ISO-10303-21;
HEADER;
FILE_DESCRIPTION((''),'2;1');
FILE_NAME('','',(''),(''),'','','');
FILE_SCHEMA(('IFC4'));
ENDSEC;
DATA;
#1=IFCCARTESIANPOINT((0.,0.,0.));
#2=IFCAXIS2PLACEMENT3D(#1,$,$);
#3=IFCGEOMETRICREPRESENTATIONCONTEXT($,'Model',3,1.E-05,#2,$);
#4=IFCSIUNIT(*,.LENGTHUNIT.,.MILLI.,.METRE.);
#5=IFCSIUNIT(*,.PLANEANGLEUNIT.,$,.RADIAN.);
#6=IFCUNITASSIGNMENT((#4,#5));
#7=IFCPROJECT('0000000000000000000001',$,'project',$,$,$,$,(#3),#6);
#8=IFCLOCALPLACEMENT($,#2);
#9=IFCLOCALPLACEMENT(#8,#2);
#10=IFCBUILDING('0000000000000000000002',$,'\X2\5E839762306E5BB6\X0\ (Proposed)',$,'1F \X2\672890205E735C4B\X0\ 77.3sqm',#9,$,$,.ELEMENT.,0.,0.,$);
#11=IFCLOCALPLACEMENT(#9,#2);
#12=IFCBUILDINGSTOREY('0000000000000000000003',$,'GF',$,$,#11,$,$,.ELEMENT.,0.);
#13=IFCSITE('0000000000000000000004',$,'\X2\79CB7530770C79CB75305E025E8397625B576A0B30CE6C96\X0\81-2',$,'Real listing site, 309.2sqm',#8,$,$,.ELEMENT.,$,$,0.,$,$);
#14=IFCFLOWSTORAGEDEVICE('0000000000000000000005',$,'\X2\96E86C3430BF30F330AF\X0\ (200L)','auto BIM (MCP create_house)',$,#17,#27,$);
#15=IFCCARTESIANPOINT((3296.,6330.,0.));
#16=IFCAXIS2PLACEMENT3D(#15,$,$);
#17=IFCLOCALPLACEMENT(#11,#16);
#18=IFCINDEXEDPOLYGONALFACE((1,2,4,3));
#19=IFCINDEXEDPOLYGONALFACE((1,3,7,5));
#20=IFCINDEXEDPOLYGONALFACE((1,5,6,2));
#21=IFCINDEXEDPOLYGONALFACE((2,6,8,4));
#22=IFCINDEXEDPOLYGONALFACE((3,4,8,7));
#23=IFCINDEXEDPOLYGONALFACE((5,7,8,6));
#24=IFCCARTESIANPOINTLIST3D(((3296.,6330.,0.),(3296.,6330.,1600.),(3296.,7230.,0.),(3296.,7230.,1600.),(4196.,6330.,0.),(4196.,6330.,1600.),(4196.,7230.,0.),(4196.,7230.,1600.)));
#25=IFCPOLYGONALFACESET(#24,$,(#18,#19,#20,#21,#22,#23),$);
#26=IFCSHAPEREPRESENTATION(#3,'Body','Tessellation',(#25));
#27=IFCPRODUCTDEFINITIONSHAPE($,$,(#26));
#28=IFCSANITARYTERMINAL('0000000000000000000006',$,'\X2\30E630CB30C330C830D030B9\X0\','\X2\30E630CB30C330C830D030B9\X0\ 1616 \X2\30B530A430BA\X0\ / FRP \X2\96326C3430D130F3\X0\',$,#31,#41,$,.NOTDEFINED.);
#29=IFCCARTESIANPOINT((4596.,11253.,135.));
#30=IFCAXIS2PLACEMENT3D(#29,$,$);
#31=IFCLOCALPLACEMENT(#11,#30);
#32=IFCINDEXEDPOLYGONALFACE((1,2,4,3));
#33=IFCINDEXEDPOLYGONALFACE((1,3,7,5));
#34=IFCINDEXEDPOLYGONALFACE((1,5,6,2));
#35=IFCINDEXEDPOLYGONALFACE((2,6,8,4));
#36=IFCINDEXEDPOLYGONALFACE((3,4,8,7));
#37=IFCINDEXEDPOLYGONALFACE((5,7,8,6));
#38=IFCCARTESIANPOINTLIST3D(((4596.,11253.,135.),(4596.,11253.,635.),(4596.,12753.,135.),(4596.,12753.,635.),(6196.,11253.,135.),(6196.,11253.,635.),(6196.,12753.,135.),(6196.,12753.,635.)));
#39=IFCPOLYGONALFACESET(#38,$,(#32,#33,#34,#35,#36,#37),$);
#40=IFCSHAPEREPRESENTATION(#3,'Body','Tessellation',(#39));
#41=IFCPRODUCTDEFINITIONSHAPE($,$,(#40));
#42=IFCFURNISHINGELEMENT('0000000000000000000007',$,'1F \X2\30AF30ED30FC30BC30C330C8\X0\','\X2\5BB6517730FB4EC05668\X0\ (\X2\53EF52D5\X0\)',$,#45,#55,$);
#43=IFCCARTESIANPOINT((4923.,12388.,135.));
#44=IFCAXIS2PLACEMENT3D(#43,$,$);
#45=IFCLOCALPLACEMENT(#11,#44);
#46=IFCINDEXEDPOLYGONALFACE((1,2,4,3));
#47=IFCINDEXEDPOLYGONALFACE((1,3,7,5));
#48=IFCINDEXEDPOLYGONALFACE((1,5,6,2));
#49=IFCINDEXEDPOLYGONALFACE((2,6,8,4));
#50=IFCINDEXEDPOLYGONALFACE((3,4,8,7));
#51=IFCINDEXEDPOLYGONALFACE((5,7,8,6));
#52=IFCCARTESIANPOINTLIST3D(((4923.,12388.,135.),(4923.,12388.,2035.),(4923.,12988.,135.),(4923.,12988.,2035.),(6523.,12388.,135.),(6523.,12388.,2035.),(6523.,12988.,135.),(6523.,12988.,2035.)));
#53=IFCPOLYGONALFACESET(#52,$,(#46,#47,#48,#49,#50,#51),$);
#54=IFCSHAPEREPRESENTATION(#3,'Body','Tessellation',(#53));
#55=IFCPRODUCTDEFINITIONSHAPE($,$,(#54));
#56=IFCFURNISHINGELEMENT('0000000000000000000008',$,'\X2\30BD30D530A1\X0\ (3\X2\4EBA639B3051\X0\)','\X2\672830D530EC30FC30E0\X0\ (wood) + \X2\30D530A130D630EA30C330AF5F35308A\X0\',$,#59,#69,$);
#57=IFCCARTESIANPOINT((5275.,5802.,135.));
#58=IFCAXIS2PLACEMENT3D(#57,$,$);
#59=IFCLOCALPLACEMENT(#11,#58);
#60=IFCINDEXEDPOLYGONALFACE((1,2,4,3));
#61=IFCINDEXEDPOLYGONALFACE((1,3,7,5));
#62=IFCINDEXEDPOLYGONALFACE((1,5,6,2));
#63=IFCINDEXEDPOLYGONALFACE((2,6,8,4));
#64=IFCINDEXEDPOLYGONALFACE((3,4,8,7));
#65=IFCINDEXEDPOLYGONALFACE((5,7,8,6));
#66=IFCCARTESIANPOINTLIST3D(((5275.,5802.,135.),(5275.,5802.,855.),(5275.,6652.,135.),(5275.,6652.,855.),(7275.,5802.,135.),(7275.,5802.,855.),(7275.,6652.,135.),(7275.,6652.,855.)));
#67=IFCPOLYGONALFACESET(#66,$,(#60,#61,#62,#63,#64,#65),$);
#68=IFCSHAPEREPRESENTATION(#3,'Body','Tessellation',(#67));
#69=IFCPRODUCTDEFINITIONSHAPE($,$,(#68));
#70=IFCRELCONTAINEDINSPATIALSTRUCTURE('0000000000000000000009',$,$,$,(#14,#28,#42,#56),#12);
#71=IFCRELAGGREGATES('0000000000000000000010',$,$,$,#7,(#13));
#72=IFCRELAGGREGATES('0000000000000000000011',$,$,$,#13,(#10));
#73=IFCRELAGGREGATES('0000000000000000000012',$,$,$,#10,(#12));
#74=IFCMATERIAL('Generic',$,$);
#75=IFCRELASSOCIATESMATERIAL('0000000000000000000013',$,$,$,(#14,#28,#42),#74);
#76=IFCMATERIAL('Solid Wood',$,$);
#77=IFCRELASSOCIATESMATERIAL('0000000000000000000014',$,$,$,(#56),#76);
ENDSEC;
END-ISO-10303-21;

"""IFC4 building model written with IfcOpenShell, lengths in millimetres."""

from ifc_helpers import new_model, si_unit, frame, frame_2d, origin, place, context, project, spatial, rectangle, extrude, material, element, save


model = new_model("IFC4")

# Units and contexts
model_context = context("Model", 3, precision=1e-05, world=origin())
ifc_project = project(units=[si_unit("LENGTHUNIT", "METRE", prefix="MILLI"), si_unit("PLANEANGLEUNIT", "RADIAN")], contexts=[model_context])

# Site, building, storey
site_placement = place(None, origin())
site = spatial("IfcSite", under=ifc_project, at=site_placement, Name="秋田県秋田市広面字樋ノ沖81-2", ObjectType="Real listing site, 309.2sqm", CompositionType="ELEMENT", RefElevation=0.0)
building_placement = place(site_placement, origin())
building = spatial("IfcBuilding", under=site, at=building_placement, Name="広面の家 (Proposed)", ObjectType="1F 木造平屋 77.3sqm", CompositionType="ELEMENT", ElevationOfRefHeight=0.0, ElevationOfTerrain=0.0)
storey_placement = place(building_placement, origin())
storey = spatial("IfcBuildingStorey", under=building, at=storey_placement, Name="GF", CompositionType="ELEMENT", Elevation=0.0)

# Shared definitions
ifc_material_1 = material(Name="Solid Wood")

# Shared definitions
ifc_material_2 = material(Name="Generic")

# Flow storage device
flow_storage_device_placement = place(storey_placement, frame((3296.0, 6330.0, 0.0)))
element("IfcFlowStorageDevice", 1, at=flow_storage_device_placement, inside=storey, material=ifc_material_2, Name="雨水タンク (200L)", Description="auto BIM (MCP create_house)", context=model_context, shape_type="SweptSolid", body=[
    extrude(rectangle(XDim=900.0, YDim=900.0, at=frame_2d((450.0, 450.0))), frame((3296.0, 6330.0, 0.0)), (0.0, 0.0, 1.0), 1600.0),
])

# Sanitary terminal
sanitary_terminal_placement = place(storey_placement, frame((4596.0, 11253.0, 135.0)))
element("IfcSanitaryTerminal", 2, at=sanitary_terminal_placement, inside=storey, material=ifc_material_2, Name="ユニットバス", Description="ユニットバス 1616 サイズ / FRP 防水パン", PredefinedType="NOTDEFINED", context=model_context, shape_type="SweptSolid", body=[
    extrude(rectangle(XDim=1600.0, YDim=1500.0, at=frame_2d((800.0, 750.0))), frame((4596.0, 11253.0, 135.0)), (0.0, 0.0, 1.0), 500.0),
])

# Furnishing elements
furnishing_1_placement = place(storey_placement, frame((4923.0, 12388.0, 135.0)))
element("IfcFurnishingElement", 3, at=furnishing_1_placement, inside=storey, material=ifc_material_2, Name="1F クローゼット", Description="家具・什器 (可動)", context=model_context, shape_type="SweptSolid", body=[
    extrude(rectangle(XDim=1600.0, YDim=600.0, at=frame_2d((800.0, 300.0))), frame((4923.0, 12388.0, 135.0)), (0.0, 0.0, 1.0), 1900.0),
])
furnishing_2_placement = place(storey_placement, frame((5275.0, 5802.0, 135.0)))
element("IfcFurnishingElement", 4, at=furnishing_2_placement, inside=storey, material=ifc_material_1, Name="ソファ (3人掛け)", Description="木フレーム (wood) + ファブリック張り", context=model_context, shape_type="SweptSolid", body=[
    extrude(rectangle(XDim=2000.0, YDim=850.0, at=frame_2d((1000.0, 425.0))), frame((5275.0, 5802.0, 135.0)), (0.0, 0.0, 1.0), 720.0),
])

save(model, "model.ifc")
